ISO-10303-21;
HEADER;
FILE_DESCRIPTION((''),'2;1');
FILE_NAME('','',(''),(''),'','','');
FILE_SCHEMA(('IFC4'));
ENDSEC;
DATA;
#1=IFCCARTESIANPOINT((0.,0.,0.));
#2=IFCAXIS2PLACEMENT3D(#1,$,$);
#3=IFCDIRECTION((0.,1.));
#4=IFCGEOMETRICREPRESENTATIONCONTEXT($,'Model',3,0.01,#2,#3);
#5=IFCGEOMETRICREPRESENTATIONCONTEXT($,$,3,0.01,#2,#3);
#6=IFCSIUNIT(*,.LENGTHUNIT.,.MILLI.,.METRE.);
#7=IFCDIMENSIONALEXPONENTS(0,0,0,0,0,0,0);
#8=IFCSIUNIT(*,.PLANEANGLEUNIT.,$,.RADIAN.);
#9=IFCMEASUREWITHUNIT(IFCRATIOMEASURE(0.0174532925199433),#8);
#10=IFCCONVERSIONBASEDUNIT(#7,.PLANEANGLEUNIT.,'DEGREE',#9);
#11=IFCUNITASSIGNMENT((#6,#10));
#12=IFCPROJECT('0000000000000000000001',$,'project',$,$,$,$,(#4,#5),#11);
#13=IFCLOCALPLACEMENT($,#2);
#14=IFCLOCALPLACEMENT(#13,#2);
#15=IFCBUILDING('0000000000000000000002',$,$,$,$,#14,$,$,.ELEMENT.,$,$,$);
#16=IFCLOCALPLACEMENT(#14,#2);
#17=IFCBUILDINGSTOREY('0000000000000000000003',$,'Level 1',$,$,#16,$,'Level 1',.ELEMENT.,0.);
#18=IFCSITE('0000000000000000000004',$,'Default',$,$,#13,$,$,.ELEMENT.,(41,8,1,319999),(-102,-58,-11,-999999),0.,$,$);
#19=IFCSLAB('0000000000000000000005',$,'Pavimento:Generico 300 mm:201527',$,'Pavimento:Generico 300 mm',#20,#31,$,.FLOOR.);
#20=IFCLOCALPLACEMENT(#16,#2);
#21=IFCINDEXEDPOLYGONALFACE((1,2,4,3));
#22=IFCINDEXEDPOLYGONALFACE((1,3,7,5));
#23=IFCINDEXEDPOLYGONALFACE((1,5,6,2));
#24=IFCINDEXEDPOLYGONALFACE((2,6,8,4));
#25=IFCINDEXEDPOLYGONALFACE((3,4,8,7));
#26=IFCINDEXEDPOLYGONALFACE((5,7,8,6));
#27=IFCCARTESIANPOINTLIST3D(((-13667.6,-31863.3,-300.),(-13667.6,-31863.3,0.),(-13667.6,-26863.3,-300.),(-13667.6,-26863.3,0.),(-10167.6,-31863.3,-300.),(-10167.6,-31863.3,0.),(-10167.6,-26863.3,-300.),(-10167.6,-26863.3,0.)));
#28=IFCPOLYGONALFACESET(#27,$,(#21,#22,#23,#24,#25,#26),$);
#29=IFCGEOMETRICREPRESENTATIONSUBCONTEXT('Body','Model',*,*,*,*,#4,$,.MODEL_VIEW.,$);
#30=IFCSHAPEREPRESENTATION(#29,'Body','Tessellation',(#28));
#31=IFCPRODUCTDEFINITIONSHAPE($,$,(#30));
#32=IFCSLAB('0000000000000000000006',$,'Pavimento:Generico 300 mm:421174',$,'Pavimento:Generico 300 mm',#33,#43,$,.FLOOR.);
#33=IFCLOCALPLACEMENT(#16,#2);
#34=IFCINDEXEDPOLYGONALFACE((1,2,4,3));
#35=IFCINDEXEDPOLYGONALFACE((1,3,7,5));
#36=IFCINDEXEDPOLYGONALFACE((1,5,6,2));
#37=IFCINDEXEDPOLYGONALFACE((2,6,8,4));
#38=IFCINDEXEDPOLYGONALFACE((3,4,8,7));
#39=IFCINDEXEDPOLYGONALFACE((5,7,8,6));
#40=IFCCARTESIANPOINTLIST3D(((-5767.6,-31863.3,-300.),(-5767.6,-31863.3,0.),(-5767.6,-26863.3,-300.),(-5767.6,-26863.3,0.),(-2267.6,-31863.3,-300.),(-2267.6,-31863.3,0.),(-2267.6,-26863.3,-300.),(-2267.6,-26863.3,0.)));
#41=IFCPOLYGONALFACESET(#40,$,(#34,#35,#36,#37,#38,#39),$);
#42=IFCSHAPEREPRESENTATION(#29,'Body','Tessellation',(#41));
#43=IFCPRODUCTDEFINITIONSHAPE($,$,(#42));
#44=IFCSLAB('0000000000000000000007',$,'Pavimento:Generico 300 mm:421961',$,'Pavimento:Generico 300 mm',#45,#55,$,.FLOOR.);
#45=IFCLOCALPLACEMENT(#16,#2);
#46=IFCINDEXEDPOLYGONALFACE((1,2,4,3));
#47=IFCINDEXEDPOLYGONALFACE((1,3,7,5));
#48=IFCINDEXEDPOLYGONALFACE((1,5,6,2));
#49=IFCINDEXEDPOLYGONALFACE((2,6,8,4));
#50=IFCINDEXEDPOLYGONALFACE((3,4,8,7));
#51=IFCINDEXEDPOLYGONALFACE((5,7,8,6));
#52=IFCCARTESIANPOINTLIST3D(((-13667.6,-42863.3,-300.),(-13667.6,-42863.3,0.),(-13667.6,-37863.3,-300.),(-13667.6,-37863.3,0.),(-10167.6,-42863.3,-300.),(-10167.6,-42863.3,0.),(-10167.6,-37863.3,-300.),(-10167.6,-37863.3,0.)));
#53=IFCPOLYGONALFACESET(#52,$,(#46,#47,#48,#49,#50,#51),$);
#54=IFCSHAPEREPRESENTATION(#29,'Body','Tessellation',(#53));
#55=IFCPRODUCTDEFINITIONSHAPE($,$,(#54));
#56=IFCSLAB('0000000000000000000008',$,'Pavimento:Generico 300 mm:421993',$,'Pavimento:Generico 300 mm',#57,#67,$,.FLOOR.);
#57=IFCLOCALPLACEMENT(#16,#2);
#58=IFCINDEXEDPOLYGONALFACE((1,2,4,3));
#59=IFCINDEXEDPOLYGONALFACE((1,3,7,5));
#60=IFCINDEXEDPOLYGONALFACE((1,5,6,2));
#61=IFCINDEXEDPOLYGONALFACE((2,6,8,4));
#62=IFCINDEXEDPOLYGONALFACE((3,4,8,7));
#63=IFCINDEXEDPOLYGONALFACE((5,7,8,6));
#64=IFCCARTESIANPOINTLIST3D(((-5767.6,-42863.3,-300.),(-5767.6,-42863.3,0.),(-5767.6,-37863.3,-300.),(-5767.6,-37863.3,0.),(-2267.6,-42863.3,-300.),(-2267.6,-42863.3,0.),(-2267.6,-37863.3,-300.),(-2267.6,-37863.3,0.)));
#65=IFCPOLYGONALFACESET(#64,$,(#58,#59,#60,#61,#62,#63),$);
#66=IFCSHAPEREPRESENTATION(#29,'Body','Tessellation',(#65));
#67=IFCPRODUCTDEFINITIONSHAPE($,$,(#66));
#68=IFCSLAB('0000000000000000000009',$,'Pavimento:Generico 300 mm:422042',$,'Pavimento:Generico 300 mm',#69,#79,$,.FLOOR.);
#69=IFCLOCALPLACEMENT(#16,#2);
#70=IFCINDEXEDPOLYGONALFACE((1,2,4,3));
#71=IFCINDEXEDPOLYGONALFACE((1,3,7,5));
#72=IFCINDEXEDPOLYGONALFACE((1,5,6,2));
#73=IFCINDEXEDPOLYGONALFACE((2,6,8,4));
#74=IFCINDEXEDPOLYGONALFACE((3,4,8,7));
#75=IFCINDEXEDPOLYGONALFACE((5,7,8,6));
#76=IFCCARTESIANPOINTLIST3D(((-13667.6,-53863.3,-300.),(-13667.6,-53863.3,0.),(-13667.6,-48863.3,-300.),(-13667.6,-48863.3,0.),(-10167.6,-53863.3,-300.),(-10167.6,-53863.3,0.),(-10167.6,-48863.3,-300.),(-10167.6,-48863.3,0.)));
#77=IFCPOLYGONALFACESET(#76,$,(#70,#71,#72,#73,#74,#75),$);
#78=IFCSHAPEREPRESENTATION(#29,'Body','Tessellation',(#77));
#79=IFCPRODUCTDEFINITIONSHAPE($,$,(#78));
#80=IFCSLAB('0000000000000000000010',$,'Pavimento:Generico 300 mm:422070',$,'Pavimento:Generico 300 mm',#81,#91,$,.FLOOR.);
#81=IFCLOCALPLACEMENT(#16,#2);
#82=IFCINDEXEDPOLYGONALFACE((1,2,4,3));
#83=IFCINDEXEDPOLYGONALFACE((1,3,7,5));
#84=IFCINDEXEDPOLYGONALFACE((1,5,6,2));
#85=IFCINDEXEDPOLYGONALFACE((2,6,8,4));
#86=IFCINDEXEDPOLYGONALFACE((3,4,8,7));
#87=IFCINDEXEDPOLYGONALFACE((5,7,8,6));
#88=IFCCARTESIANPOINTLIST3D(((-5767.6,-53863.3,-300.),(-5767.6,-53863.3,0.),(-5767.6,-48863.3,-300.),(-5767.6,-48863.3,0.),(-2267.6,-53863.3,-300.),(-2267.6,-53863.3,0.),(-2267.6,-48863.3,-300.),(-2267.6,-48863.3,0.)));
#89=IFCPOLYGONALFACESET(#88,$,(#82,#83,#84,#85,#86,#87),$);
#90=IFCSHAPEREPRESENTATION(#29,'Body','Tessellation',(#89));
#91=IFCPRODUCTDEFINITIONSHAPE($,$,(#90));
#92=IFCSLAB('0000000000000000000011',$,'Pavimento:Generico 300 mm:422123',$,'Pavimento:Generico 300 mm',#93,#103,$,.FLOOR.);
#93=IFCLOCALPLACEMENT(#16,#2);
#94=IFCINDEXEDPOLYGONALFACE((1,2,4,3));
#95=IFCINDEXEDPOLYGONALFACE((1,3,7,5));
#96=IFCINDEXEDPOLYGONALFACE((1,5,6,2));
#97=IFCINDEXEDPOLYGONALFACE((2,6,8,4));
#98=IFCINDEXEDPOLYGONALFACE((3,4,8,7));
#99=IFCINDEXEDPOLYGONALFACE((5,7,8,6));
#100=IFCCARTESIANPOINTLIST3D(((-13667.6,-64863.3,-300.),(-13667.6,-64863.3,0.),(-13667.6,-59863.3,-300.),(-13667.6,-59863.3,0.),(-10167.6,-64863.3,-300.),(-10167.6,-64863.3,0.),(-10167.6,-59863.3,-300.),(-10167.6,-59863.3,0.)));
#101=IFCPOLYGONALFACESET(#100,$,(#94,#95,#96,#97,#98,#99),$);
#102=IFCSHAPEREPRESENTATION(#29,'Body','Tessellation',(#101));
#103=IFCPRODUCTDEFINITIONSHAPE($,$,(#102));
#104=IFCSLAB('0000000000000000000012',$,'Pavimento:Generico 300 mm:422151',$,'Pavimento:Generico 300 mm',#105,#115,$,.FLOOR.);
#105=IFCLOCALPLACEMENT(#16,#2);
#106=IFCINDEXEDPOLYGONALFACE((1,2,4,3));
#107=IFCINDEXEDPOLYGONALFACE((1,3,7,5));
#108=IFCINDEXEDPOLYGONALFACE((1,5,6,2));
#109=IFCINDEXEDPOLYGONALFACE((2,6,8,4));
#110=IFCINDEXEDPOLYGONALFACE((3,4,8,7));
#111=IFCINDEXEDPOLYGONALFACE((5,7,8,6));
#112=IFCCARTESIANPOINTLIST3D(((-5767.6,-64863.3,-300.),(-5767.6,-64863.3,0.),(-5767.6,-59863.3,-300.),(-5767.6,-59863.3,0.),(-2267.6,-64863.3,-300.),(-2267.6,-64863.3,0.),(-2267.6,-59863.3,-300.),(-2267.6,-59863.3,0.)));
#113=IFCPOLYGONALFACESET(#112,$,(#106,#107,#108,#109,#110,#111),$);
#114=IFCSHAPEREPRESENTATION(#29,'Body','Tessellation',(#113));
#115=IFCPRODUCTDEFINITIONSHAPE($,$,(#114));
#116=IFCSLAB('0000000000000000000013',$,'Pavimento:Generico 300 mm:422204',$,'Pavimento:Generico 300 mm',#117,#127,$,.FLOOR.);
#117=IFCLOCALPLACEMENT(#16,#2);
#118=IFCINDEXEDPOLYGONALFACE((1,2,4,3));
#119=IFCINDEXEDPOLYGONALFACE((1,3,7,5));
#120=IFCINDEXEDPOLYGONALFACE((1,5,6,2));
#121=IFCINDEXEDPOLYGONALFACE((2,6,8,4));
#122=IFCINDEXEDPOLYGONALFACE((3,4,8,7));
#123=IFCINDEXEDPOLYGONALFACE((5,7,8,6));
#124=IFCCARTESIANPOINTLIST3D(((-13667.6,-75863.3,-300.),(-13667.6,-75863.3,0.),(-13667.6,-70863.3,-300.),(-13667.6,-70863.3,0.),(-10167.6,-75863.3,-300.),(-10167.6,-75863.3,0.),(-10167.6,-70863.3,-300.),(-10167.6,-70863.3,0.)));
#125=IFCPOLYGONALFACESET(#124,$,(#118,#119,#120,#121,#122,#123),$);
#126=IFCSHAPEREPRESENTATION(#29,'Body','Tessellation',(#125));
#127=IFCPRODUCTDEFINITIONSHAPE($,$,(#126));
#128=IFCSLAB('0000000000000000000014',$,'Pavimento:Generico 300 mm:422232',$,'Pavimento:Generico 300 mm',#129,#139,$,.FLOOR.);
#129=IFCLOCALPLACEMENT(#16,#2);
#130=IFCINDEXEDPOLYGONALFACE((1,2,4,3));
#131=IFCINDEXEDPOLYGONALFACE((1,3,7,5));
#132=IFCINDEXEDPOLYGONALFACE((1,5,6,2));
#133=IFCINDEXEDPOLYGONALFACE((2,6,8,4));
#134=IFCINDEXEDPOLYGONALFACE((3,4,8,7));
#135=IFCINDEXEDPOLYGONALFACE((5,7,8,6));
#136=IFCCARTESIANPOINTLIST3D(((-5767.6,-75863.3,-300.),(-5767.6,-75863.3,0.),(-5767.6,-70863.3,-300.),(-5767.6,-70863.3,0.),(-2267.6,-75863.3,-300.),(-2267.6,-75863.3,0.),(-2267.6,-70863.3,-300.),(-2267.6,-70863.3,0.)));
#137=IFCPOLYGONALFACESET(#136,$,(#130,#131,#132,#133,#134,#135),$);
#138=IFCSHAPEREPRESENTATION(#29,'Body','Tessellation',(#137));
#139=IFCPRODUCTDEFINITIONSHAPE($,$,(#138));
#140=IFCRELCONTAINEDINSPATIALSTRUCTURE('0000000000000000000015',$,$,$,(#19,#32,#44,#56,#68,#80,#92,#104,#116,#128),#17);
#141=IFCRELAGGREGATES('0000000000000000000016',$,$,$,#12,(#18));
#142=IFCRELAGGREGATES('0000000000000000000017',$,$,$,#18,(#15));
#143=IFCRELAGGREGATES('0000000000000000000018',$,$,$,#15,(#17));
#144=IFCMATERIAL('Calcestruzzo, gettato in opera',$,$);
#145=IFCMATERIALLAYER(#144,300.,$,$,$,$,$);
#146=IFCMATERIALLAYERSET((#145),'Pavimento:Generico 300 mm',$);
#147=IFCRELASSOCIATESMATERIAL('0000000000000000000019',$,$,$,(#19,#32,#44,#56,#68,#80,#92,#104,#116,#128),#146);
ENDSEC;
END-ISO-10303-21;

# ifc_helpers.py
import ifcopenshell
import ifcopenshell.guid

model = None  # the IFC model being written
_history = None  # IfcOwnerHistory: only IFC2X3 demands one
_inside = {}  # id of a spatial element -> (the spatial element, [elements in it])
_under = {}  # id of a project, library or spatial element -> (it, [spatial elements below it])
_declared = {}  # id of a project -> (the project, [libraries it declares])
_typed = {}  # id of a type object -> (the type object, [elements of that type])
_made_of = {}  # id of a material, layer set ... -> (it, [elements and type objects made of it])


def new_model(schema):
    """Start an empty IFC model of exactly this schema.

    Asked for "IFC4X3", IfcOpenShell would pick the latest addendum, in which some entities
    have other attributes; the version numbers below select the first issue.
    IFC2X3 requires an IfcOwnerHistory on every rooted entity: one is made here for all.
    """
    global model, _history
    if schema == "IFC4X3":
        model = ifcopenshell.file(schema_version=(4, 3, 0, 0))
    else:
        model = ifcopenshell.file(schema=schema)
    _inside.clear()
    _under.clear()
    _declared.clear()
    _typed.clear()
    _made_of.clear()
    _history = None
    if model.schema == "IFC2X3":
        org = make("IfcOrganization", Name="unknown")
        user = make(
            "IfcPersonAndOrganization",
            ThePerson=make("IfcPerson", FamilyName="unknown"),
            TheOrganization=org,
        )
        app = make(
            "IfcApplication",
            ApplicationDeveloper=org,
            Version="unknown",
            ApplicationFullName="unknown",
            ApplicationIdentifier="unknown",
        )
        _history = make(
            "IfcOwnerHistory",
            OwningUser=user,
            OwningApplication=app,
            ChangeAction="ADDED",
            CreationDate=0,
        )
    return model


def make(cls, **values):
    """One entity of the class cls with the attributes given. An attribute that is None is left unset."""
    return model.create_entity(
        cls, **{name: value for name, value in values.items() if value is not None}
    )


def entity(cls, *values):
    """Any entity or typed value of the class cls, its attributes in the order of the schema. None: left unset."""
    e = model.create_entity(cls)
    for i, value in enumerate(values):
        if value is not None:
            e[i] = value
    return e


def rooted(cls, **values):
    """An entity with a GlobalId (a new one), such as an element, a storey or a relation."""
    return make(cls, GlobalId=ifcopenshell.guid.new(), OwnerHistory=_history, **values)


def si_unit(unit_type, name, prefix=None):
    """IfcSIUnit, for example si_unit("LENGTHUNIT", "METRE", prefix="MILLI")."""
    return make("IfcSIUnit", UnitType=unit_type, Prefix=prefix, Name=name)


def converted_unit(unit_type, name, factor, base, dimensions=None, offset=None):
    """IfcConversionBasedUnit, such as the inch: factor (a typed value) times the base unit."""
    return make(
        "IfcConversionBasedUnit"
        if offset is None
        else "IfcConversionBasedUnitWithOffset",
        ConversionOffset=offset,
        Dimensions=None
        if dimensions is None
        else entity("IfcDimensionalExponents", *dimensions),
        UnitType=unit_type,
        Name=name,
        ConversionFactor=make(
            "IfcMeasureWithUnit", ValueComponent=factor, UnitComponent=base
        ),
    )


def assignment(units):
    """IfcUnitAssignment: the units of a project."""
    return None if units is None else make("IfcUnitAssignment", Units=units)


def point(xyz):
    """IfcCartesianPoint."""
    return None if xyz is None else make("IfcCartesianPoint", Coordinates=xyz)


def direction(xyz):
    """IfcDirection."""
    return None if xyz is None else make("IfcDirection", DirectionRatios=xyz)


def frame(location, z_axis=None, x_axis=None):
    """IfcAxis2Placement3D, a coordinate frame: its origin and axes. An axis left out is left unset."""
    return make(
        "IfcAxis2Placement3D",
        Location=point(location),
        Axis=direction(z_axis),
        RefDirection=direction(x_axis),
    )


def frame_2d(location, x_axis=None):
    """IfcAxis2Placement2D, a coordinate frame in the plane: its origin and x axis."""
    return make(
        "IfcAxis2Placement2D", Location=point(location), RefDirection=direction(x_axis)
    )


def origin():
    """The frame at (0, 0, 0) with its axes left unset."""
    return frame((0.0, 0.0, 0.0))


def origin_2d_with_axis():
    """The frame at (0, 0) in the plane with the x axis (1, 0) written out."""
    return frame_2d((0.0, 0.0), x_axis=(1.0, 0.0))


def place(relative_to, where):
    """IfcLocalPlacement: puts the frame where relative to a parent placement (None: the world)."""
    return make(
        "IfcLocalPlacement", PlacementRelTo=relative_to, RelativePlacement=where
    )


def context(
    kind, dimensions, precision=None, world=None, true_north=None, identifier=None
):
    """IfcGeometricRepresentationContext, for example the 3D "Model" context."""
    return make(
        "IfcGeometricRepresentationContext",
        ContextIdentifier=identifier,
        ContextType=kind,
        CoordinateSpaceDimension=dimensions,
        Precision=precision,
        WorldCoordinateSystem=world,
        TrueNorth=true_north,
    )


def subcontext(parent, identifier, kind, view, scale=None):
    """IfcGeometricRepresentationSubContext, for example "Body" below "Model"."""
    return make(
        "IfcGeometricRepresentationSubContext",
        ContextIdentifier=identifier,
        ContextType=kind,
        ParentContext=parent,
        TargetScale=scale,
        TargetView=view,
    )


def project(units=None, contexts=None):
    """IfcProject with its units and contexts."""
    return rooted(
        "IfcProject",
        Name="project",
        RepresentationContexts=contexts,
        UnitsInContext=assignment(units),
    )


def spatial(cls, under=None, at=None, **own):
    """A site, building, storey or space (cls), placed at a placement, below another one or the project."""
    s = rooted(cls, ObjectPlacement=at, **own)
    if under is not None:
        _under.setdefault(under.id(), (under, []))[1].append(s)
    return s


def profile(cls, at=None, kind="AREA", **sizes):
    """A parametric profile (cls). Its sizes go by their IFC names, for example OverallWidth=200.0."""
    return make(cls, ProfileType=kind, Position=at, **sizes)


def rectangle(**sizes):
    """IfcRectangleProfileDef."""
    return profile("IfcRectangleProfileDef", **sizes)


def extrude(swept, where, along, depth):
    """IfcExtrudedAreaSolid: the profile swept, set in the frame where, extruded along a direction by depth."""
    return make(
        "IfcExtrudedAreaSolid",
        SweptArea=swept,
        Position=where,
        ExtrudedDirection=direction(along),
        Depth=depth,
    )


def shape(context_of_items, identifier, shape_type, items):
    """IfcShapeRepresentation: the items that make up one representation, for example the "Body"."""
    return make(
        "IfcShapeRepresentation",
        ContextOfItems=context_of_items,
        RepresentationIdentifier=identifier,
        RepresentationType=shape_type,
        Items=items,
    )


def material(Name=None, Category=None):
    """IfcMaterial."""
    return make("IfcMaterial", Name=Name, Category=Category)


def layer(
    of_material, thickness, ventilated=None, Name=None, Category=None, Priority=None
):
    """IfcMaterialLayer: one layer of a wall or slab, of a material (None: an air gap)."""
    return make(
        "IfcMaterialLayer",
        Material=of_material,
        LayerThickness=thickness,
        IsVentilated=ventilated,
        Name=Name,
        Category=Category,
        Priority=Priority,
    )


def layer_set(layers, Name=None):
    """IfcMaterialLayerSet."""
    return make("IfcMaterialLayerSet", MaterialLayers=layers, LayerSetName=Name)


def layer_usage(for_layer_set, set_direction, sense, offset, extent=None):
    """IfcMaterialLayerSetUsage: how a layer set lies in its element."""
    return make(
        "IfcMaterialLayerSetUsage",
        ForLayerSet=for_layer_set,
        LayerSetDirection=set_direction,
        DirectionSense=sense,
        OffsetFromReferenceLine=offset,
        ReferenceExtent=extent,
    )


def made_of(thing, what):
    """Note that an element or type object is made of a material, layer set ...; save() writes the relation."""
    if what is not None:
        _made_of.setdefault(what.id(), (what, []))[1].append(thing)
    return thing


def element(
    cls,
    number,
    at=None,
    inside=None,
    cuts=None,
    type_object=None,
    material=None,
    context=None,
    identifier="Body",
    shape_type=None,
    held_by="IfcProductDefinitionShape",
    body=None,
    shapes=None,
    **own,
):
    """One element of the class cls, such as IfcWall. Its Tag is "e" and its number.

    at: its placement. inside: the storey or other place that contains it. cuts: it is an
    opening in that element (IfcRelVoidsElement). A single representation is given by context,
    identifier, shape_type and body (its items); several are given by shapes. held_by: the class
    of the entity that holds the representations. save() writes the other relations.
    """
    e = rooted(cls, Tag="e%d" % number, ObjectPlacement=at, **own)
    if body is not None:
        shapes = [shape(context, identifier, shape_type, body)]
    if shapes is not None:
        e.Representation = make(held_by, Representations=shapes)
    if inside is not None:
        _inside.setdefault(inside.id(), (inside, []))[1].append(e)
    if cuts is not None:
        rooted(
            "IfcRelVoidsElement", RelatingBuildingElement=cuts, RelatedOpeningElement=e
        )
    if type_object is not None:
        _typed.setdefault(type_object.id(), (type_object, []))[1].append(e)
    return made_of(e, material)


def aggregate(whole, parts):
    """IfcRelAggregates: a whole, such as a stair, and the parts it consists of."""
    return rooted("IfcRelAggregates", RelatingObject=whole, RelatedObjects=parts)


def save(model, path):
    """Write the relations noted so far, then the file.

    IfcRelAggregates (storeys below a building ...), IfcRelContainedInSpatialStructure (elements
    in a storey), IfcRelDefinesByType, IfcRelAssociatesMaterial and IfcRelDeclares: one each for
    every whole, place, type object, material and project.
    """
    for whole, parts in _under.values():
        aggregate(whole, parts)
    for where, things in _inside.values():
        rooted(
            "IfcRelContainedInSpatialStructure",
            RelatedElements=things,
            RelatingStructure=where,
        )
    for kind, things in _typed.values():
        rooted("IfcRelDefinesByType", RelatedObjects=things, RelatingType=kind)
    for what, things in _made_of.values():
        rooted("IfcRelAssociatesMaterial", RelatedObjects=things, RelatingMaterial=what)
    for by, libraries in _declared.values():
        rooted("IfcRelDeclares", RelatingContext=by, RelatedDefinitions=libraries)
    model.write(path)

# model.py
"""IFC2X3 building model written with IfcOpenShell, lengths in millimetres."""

from ifc_helpers import new_model, entity, si_unit, converted_unit, direction, frame, frame_2d, origin, origin_2d_with_axis, place, context, subcontext, project, spatial, rectangle, extrude, material, layer, layer_set, layer_usage, element, save


model = new_model("IFC2X3")

# Units and contexts
model_context = context("Model", 3, precision=0.01, world=origin(), true_north=direction((0.0, 1.0)))
context_of_model = context(None, 3, precision=0.01, world=origin(), true_north=direction((0.0, 1.0)))
body_context = subcontext(model_context, "Body", "Model", "MODEL_VIEW")
ifc_project = project(units=[si_unit("LENGTHUNIT", "METRE", prefix="MILLI"), converted_unit("PLANEANGLEUNIT", "DEGREE", entity("IfcRatioMeasure", 0.0174532925199433), si_unit("PLANEANGLEUNIT", "RADIAN"), dimensions=[0, 0, 0, 0, 0, 0, 0])], contexts=[model_context, context_of_model])

# Site, building, storey
site_placement = place(None, origin())
site = spatial("IfcSite", under=ifc_project, at=site_placement, Name="Default", CompositionType="ELEMENT", RefLatitude=(41, 8, 1, 319999), RefLongitude=(-102, -58, -11, -999999), RefElevation=0.0)
building_placement = place(site_placement, origin())
building = spatial("IfcBuilding", under=site, at=building_placement, CompositionType="ELEMENT")
storey_placement = place(building_placement, origin())
storey = spatial("IfcBuildingStorey", under=building, at=storey_placement, Name="Level 1", LongName="Level 1", CompositionType="ELEMENT", Elevation=0.0)

# Slabs
ifc_material = material(Name="Calcestruzzo, gettato in opera")
ifc_layer = layer(ifc_material, 300.0)
ifc_layer_set = layer_set([ifc_layer], Name="Pavimento:Generico 300 mm")
ifc_layer_usage_1 = layer_usage(ifc_layer_set, "AXIS3", "POSITIVE", 0.0)
slab_1_placement = place(storey_placement, origin())
element("IfcSlab", 1, at=slab_1_placement, inside=storey, material=ifc_layer_usage_1, Name="Pavimento:Generico 300 mm:201527", ObjectType="Pavimento:Generico 300 mm", PredefinedType="FLOOR", context=body_context, shape_type="SweptSolid", body=[
    extrude(rectangle(XDim=5000.0, YDim=3500.0, at=frame_2d((0.0, 0.0), x_axis=(1.0, 0.0))), frame((-11917.6, -29363.3, 0.0), z_axis=(0.0, 0.0, -1.0), x_axis=(0.0, 1.0, 0.0)), (0.0, 0.0, 1.0), 300.0),
])
ifc_layer_usage_2 = layer_usage(ifc_layer_set, "AXIS3", "POSITIVE", 0.0)
slab_2_placement = place(storey_placement, origin())
element("IfcSlab", 2, at=slab_2_placement, inside=storey, material=ifc_layer_usage_2, Name="Pavimento:Generico 300 mm:421174", ObjectType="Pavimento:Generico 300 mm", PredefinedType="FLOOR", context=body_context, shape_type="SweptSolid", body=[
    extrude(rectangle(XDim=5000.0, YDim=3500.0, at=origin_2d_with_axis()), frame((-4017.6, -29363.3, 0.0), z_axis=(0.0, 0.0, -1.0), x_axis=(0.0, 1.0, 0.0)), (0.0, 0.0, 1.0), 300.0),
])
ifc_layer_usage_3 = layer_usage(ifc_layer_set, "AXIS3", "POSITIVE", 0.0)
slab_3_placement = place(storey_placement, origin())
element("IfcSlab", 3, at=slab_3_placement, inside=storey, material=ifc_layer_usage_3, Name="Pavimento:Generico 300 mm:421961", ObjectType="Pavimento:Generico 300 mm", PredefinedType="FLOOR", context=body_context, shape_type="SweptSolid", body=[
    extrude(rectangle(XDim=5000.0, YDim=3500.0, at=frame_2d((0.0, 0.0), x_axis=(1.0, 0.0))), frame((-11917.6, -40363.3, 0.0), z_axis=(0.0, 0.0, -1.0), x_axis=(0.0, 1.0, 0.0)), (0.0, 0.0, 1.0), 300.0),
])
ifc_layer_usage_4 = layer_usage(ifc_layer_set, "AXIS3", "POSITIVE", 0.0)
slab_4_placement = place(storey_placement, origin())
element("IfcSlab", 4, at=slab_4_placement, inside=storey, material=ifc_layer_usage_4, Name="Pavimento:Generico 300 mm:421993", ObjectType="Pavimento:Generico 300 mm", PredefinedType="FLOOR", context=body_context, shape_type="SweptSolid", body=[
    extrude(rectangle(XDim=5000.0, YDim=3500.0, at=frame_2d((0.0, 0.0), x_axis=(1.0, 0.0))), frame((-4017.6, -40363.3, 0.0), z_axis=(0.0, 0.0, -1.0), x_axis=(0.0, 1.0, 0.0)), (0.0, 0.0, 1.0), 300.0),
])
ifc_layer_usage_5 = layer_usage(ifc_layer_set, "AXIS3", "POSITIVE", 0.0)
slab_5_placement = place(storey_placement, origin())
element("IfcSlab", 5, at=slab_5_placement, inside=storey, material=ifc_layer_usage_5, Name="Pavimento:Generico 300 mm:422042", ObjectType="Pavimento:Generico 300 mm", PredefinedType="FLOOR", context=body_context, shape_type="SweptSolid", body=[
    extrude(rectangle(XDim=5000.0, YDim=3500.0, at=frame_2d((0.0, 0.0), x_axis=(1.0, 0.0))), frame((-11917.6, -51363.3, 0.0), z_axis=(0.0, 0.0, -1.0), x_axis=(0.0, 1.0, 0.0)), (0.0, 0.0, 1.0), 300.0),
])
ifc_layer_usage_6 = layer_usage(ifc_layer_set, "AXIS3", "POSITIVE", 0.0)
slab_6_placement = place(storey_placement, origin())
element("IfcSlab", 6, at=slab_6_placement, inside=storey, material=ifc_layer_usage_6, Name="Pavimento:Generico 300 mm:422070", ObjectType="Pavimento:Generico 300 mm", PredefinedType="FLOOR", context=body_context, shape_type="SweptSolid", body=[
    extrude(rectangle(XDim=5000.0, YDim=3500.0, at=origin_2d_with_axis()), frame((-4017.6, -51363.3, 0.0), z_axis=(0.0, 0.0, -1.0), x_axis=(0.0, 1.0, 0.0)), (0.0, 0.0, 1.0), 300.0),
])
ifc_layer_usage_7 = layer_usage(ifc_layer_set, "AXIS3", "POSITIVE", 0.0)
slab_7_placement = place(storey_placement, origin())
element("IfcSlab", 7, at=slab_7_placement, inside=storey, material=ifc_layer_usage_7, Name="Pavimento:Generico 300 mm:422123", ObjectType="Pavimento:Generico 300 mm", PredefinedType="FLOOR", context=body_context, shape_type="SweptSolid", body=[
    extrude(rectangle(XDim=5000.0, YDim=3500.0, at=frame_2d((0.0, 0.0), x_axis=(1.0, 0.0))), frame((-11917.6, -62363.3, 0.0), z_axis=(0.0, 0.0, -1.0), x_axis=(0.0, 1.0, 0.0)), (0.0, 0.0, 1.0), 300.0),
])
ifc_layer_usage_8 = layer_usage(ifc_layer_set, "AXIS3", "POSITIVE", 0.0)
slab_8_placement = place(storey_placement, origin())
element("IfcSlab", 8, at=slab_8_placement, inside=storey, material=ifc_layer_usage_8, Name="Pavimento:Generico 300 mm:422151", ObjectType="Pavimento:Generico 300 mm", PredefinedType="FLOOR", context=body_context, shape_type="SweptSolid", body=[
    extrude(rectangle(XDim=5000.0, YDim=3500.0, at=origin_2d_with_axis()), frame((-4017.6, -62363.3, 0.0), z_axis=(0.0, 0.0, -1.0), x_axis=(0.0, 1.0, 0.0)), (0.0, 0.0, 1.0), 300.0),
])
ifc_layer_usage_9 = layer_usage(ifc_layer_set, "AXIS3", "POSITIVE", 0.0)
slab_9_placement = place(storey_placement, origin())
element("IfcSlab", 9, at=slab_9_placement, inside=storey, material=ifc_layer_usage_9, Name="Pavimento:Generico 300 mm:422204", ObjectType="Pavimento:Generico 300 mm", PredefinedType="FLOOR", context=body_context, shape_type="SweptSolid", body=[
    extrude(rectangle(XDim=5000.0, YDim=3500.0, at=frame_2d((0.0, 0.0), x_axis=(1.0, 0.0))), frame((-11917.6, -73363.3, 0.0), z_axis=(0.0, 0.0, -1.0), x_axis=(0.0, 1.0, 0.0)), (0.0, 0.0, 1.0), 300.0),
])
ifc_layer_usage_10 = layer_usage(ifc_layer_set, "AXIS3", "POSITIVE", 0.0)
slab_10_placement = place(storey_placement, origin())
element("IfcSlab", 10, at=slab_10_placement, inside=storey, material=ifc_layer_usage_10, Name="Pavimento:Generico 300 mm:422232", ObjectType="Pavimento:Generico 300 mm", PredefinedType="FLOOR", context=body_context, shape_type="SweptSolid", body=[
    extrude(rectangle(XDim=5000.0, YDim=3500.0, at=origin_2d_with_axis()), frame((-4017.6, -73363.3, 0.0), z_axis=(0.0, 0.0, -1.0), x_axis=(0.0, 1.0, 0.0)), (0.0, 0.0, 1.0), 300.0),
])

save(model, "model.ifc")
